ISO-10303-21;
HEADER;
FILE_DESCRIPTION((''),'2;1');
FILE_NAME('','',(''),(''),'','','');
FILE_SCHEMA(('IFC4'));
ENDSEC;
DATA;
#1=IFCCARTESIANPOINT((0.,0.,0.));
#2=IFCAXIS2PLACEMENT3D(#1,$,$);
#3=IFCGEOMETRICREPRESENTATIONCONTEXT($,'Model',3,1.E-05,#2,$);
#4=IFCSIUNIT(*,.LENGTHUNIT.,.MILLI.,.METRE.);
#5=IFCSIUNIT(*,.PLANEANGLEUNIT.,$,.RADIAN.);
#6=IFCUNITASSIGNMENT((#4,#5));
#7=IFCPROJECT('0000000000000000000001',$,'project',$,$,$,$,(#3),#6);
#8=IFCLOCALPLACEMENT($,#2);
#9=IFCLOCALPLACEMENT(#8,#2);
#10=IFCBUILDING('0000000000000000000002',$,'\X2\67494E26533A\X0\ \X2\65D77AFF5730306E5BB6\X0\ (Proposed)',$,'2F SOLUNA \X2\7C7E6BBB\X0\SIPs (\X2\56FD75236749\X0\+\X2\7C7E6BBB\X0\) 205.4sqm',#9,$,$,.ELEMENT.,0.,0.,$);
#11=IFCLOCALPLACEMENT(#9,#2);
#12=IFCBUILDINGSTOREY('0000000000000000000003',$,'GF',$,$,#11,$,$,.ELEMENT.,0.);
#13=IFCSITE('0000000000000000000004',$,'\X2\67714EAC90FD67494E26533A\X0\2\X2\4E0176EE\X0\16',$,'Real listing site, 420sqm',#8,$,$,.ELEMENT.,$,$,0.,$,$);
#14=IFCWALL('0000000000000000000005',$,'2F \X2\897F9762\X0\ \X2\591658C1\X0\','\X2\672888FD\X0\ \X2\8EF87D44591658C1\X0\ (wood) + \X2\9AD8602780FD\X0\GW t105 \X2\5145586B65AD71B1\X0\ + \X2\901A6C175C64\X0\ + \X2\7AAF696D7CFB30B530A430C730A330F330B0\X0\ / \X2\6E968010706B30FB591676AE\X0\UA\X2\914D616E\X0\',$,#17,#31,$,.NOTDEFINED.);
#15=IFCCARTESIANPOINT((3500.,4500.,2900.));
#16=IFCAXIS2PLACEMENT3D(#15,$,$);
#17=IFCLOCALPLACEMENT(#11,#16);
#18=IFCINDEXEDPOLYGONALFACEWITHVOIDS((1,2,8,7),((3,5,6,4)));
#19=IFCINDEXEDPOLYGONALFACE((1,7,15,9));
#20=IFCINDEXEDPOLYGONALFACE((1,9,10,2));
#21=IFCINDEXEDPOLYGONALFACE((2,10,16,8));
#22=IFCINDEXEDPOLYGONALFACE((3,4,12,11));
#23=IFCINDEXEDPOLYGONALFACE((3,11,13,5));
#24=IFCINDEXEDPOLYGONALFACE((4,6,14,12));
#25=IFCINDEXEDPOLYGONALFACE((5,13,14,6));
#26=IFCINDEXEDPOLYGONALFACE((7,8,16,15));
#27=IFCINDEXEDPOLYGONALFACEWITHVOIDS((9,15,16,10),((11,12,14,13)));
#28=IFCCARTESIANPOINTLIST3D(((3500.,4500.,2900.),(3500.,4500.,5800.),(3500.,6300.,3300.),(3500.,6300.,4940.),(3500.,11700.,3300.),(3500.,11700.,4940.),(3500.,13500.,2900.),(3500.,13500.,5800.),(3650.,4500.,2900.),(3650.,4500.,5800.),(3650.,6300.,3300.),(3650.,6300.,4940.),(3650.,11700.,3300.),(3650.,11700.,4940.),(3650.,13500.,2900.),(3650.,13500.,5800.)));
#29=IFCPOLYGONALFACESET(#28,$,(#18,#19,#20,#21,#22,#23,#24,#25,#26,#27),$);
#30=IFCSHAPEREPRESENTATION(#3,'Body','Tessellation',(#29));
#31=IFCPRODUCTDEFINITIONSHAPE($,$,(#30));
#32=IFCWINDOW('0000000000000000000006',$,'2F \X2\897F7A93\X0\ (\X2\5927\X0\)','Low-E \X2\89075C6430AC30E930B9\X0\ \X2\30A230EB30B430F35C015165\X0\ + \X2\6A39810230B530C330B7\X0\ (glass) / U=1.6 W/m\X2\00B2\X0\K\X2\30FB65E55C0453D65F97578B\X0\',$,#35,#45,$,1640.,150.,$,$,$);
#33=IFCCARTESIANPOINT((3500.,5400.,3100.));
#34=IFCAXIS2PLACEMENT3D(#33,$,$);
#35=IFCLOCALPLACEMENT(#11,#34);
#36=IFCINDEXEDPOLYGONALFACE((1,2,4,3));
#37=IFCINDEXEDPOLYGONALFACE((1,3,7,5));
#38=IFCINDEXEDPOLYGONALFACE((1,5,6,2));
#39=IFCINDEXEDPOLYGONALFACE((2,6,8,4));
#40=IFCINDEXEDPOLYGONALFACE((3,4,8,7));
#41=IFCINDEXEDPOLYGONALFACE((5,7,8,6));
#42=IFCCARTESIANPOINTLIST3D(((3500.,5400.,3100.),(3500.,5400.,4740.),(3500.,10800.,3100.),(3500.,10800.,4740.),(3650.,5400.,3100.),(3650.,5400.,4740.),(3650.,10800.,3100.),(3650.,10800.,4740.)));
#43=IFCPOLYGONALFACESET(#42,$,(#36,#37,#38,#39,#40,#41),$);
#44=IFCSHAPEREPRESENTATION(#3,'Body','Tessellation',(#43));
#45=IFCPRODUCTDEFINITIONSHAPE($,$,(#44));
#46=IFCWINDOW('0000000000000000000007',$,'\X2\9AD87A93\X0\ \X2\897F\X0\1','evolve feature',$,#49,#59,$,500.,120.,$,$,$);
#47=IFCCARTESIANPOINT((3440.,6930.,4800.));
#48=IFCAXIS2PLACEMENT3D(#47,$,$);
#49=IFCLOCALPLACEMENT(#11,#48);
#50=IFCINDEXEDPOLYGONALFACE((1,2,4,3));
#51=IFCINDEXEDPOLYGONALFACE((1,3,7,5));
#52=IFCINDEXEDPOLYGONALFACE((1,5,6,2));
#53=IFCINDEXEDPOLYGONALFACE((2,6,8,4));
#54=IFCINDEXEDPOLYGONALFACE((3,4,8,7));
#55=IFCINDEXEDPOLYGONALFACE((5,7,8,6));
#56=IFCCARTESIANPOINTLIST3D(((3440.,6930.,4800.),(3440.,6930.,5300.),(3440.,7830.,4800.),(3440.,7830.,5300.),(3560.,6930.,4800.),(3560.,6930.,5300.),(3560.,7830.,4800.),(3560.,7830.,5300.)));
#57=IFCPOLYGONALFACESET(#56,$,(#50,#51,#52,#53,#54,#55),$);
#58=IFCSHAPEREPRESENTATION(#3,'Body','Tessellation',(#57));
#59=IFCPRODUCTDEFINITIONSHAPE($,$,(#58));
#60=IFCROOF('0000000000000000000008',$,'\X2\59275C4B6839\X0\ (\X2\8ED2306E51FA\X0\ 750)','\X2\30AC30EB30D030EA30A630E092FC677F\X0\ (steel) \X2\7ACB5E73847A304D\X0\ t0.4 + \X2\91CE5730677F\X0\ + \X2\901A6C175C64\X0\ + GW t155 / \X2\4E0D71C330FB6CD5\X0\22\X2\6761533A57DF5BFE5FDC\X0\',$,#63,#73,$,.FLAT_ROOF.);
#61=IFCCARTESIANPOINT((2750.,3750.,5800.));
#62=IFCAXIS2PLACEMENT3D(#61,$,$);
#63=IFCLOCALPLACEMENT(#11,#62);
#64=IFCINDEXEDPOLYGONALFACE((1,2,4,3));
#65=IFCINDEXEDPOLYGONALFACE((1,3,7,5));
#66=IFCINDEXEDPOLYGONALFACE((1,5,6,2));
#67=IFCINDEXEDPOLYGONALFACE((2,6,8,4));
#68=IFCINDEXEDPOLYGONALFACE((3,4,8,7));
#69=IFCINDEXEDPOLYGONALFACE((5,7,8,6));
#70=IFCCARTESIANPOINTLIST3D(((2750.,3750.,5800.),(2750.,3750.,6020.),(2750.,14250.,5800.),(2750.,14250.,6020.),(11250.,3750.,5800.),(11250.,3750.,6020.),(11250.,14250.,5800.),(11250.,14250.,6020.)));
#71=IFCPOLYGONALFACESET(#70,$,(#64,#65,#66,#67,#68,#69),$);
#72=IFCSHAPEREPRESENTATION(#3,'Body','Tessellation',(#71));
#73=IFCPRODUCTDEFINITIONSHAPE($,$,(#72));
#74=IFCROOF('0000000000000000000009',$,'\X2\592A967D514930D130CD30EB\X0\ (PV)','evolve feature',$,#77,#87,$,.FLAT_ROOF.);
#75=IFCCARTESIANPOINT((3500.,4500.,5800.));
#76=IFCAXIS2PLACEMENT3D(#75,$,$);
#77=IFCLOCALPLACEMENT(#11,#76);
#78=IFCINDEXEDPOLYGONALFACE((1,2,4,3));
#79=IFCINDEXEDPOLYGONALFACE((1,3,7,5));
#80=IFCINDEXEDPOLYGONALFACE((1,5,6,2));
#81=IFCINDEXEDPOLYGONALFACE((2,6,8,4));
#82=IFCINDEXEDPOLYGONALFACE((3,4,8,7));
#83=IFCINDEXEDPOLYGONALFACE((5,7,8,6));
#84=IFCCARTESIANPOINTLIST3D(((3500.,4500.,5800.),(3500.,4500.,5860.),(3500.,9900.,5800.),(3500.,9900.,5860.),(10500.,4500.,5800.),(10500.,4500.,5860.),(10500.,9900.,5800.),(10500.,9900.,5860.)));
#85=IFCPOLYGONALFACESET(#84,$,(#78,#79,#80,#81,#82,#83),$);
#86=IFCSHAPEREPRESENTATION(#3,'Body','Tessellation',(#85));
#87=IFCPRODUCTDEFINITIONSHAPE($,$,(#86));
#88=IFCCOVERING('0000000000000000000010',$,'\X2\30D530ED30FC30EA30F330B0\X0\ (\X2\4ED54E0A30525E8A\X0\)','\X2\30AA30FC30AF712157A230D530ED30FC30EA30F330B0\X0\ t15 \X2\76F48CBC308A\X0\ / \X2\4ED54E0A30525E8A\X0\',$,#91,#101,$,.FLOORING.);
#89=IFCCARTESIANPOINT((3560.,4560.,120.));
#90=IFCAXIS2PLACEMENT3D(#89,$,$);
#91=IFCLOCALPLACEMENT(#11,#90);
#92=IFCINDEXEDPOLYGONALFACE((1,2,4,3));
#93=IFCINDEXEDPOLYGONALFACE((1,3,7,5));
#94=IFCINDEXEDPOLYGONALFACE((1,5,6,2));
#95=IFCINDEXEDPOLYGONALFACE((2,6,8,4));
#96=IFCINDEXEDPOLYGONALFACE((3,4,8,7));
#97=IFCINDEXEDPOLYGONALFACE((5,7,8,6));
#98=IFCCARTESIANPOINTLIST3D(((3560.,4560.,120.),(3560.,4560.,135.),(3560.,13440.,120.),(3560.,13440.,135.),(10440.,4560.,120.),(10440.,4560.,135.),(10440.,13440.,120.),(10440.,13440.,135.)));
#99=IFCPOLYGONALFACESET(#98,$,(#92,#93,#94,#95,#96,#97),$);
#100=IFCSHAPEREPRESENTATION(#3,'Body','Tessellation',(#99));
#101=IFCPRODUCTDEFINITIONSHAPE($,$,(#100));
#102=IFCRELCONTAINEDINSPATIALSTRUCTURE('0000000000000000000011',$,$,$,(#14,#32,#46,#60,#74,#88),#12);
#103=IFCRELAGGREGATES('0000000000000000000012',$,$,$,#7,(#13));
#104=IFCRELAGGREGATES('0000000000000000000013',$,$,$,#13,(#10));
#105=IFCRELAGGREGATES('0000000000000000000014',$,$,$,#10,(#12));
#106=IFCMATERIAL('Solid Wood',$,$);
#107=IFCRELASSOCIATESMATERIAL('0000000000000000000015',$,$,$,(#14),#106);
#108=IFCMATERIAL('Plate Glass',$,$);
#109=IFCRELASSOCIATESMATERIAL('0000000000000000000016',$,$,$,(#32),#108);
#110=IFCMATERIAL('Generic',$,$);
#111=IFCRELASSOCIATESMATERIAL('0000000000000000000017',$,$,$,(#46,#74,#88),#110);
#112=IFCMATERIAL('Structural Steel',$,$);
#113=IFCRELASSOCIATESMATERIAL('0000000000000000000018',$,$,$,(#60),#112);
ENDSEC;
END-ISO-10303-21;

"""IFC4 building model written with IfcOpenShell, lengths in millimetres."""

from ifc_helpers import new_model, si_unit, frame, frame_2d, origin, place, context, project, spatial, rectangle, extrude, material, element, fill, save


model = new_model("IFC4")

# Units and contexts
model_context = context("Model", 3, precision=1e-05, world=origin())
ifc_project = project(units=[si_unit("LENGTHUNIT", "METRE", prefix="MILLI"), si_unit("PLANEANGLEUNIT", "RADIAN")], contexts=[model_context])

# Site, building, storey
site_placement = place(None, origin())
site = spatial("IfcSite", under=ifc_project, at=site_placement, Name="東京都杉並区2丁目16", ObjectType="Real listing site, 420sqm", CompositionType="ELEMENT", RefElevation=0.0)
building_placement = place(site_placement, origin())
building = spatial("IfcBuilding", under=site, at=building_placement, Name="杉並区 旗竿地の家 (Proposed)", ObjectType="2F SOLUNA 籾殻SIPs (国産杉+籾殻) 205.4sqm", CompositionType="ELEMENT", ElevationOfRefHeight=0.0, ElevationOfTerrain=0.0)
storey_placement = place(building_placement, origin())
storey = spatial("IfcBuildingStorey", under=building, at=storey_placement, Name="GF", CompositionType="ELEMENT", Elevation=0.0)

# Shared definitions
ifc_material_1 = material(Name="Solid Wood")

# Shared definitions
ifc_material_2 = material(Name="Plate Glass")
ifc_material_3 = material(Name="Generic")

# Wall, openings, windows
wall_1_placement = place(storey_placement, frame((3500.0, 4500.0, 2900.0)))
wall_1 = element("IfcWall", 1, at=wall_1_placement, inside=storey, material=ifc_material_1, Name="2F 西面 外壁", Description="木製 軸組外壁 (wood) + 高性能GW t105 充填断熱 + 通気層 + 窯業系サイディング / 準耐火・外皮UA配慮", PredefinedType="NOTDEFINED", context=model_context, shape_type="SweptSolid", body=[
    extrude(rectangle(XDim=150.0, YDim=9000.0, at=frame_2d((75.0, 4500.0))), frame((3500.0, 4500.0, 2900.0)), (0.0, 0.0, 1.0), 2900.0),
])
opening_1_placement = place(storey_placement, frame((3500.0, 5400.0, 3100.0)))
opening_1 = element("IfcOpeningElement", 2, at=opening_1_placement, cuts=wall_1, PredefinedType="NOTDEFINED", context=model_context, shape_type="SweptSolid", body=[
    extrude(rectangle(XDim=150.0, YDim=5400.0, at=frame_2d((75.0, 2700.0))), frame((3500.0, 5400.0, 3100.0)), (0.0, 0.0, 1.0), 1640.0),
])
opening_2_placement = place(storey_placement, frame((3440.0, 6930.0, 4800.0)))
opening_2 = element("IfcOpeningElement", 3, at=opening_2_placement, cuts=wall_1, PredefinedType="NOTDEFINED", context=model_context, shape_type="SweptSolid", body=[
    extrude(rectangle(XDim=120.0, YDim=900.0, at=frame_2d((60.0, 450.0))), frame((3440.0, 6930.0, 4800.0)), (0.0, 0.0, 1.0), 500.0),
])
window_1_placement = place(storey_placement, frame((3500.0, 5400.0, 3100.0)))
window_1 = element("IfcWindow", 4, at=window_1_placement, inside=storey, material=ifc_material_2, Name="2F 西窓 (大)", Description="Low-E 複層ガラス アルゴン封入 + 樹脂サッシ (glass) / U=1.6 W/m²K・日射取得型", OverallHeight=1640.0, OverallWidth=150.0, context=model_context, shape_type="SweptSolid", body=[
    extrude(rectangle(XDim=150.0, YDim=5400.0, at=frame_2d((75.0, 2700.0))), frame((3500.0, 5400.0, 3100.0)), (0.0, 0.0, 1.0), 1640.0),
])
fill(opening_1, window_1)
window_2_placement = place(storey_placement, frame((3440.0, 6930.0, 4800.0)))
window_2 = element("IfcWindow", 5, at=window_2_placement, inside=storey, material=ifc_material_3, Name="高窓 西1", Description="evolve feature", OverallHeight=500.0, OverallWidth=120.0, context=model_context, shape_type="SweptSolid", body=[
    extrude(rectangle(XDim=120.0, YDim=900.0, at=frame_2d((60.0, 450.0))), frame((3440.0, 6930.0, 4800.0)), (0.0, 0.0, 1.0), 500.0),
])
fill(opening_2, window_2)

# Roofs
ifc_material_4 = material(Name="Structural Steel")
roof_1_placement = place(storey_placement, frame((2750.0, 3750.0, 5800.0)))
element("IfcRoof", 6, at=roof_1_placement, inside=storey, material=ifc_material_4, Name="大屋根 (軒の出 750)", Description="ガルバリウム鋼板 (steel) 立平葺き t0.4 + 野地板 + 通気層 + GW t155 / 不燃・法22条区域対応", PredefinedType="FLAT_ROOF", context=model_context, shape_type="SweptSolid", body=[
    extrude(rectangle(XDim=8500.0, YDim=10500.0, at=frame_2d((4250.0, 5250.0))), frame((2750.0, 3750.0, 5800.0)), (0.0, 0.0, 1.0), 220.0),
])
roof_2_placement = place(storey_placement, frame((3500.0, 4500.0, 5800.0)))
element("IfcRoof", 7, at=roof_2_placement, inside=storey, material=ifc_material_3, Name="太陽光パネル (PV)", Description="evolve feature", PredefinedType="FLAT_ROOF", context=model_context, shape_type="SweptSolid", body=[
    extrude(rectangle(XDim=7000.0, YDim=5400.0, at=frame_2d((3500.0, 2700.0))), frame((3500.0, 4500.0, 5800.0)), (0.0, 0.0, 1.0), 60.0),
])

# Covering
covering_placement = place(storey_placement, frame((3560.0, 4560.0, 120.0)))
element("IfcCovering", 8, at=covering_placement, inside=storey, material=ifc_material_3, Name="フローリング (仕上げ床)", Description="オーク無垢フローリング t15 直貼り / 仕上げ床", PredefinedType="FLOORING", context=model_context, shape_type="SweptSolid", body=[
    extrude(rectangle(XDim=6880.0, YDim=8880.0, at=frame_2d((3440.0, 4440.0))), frame((3560.0, 4560.0, 120.0)), (0.0, 0.0, 1.0), 15.0),
])

save(model, "model.ifc")
